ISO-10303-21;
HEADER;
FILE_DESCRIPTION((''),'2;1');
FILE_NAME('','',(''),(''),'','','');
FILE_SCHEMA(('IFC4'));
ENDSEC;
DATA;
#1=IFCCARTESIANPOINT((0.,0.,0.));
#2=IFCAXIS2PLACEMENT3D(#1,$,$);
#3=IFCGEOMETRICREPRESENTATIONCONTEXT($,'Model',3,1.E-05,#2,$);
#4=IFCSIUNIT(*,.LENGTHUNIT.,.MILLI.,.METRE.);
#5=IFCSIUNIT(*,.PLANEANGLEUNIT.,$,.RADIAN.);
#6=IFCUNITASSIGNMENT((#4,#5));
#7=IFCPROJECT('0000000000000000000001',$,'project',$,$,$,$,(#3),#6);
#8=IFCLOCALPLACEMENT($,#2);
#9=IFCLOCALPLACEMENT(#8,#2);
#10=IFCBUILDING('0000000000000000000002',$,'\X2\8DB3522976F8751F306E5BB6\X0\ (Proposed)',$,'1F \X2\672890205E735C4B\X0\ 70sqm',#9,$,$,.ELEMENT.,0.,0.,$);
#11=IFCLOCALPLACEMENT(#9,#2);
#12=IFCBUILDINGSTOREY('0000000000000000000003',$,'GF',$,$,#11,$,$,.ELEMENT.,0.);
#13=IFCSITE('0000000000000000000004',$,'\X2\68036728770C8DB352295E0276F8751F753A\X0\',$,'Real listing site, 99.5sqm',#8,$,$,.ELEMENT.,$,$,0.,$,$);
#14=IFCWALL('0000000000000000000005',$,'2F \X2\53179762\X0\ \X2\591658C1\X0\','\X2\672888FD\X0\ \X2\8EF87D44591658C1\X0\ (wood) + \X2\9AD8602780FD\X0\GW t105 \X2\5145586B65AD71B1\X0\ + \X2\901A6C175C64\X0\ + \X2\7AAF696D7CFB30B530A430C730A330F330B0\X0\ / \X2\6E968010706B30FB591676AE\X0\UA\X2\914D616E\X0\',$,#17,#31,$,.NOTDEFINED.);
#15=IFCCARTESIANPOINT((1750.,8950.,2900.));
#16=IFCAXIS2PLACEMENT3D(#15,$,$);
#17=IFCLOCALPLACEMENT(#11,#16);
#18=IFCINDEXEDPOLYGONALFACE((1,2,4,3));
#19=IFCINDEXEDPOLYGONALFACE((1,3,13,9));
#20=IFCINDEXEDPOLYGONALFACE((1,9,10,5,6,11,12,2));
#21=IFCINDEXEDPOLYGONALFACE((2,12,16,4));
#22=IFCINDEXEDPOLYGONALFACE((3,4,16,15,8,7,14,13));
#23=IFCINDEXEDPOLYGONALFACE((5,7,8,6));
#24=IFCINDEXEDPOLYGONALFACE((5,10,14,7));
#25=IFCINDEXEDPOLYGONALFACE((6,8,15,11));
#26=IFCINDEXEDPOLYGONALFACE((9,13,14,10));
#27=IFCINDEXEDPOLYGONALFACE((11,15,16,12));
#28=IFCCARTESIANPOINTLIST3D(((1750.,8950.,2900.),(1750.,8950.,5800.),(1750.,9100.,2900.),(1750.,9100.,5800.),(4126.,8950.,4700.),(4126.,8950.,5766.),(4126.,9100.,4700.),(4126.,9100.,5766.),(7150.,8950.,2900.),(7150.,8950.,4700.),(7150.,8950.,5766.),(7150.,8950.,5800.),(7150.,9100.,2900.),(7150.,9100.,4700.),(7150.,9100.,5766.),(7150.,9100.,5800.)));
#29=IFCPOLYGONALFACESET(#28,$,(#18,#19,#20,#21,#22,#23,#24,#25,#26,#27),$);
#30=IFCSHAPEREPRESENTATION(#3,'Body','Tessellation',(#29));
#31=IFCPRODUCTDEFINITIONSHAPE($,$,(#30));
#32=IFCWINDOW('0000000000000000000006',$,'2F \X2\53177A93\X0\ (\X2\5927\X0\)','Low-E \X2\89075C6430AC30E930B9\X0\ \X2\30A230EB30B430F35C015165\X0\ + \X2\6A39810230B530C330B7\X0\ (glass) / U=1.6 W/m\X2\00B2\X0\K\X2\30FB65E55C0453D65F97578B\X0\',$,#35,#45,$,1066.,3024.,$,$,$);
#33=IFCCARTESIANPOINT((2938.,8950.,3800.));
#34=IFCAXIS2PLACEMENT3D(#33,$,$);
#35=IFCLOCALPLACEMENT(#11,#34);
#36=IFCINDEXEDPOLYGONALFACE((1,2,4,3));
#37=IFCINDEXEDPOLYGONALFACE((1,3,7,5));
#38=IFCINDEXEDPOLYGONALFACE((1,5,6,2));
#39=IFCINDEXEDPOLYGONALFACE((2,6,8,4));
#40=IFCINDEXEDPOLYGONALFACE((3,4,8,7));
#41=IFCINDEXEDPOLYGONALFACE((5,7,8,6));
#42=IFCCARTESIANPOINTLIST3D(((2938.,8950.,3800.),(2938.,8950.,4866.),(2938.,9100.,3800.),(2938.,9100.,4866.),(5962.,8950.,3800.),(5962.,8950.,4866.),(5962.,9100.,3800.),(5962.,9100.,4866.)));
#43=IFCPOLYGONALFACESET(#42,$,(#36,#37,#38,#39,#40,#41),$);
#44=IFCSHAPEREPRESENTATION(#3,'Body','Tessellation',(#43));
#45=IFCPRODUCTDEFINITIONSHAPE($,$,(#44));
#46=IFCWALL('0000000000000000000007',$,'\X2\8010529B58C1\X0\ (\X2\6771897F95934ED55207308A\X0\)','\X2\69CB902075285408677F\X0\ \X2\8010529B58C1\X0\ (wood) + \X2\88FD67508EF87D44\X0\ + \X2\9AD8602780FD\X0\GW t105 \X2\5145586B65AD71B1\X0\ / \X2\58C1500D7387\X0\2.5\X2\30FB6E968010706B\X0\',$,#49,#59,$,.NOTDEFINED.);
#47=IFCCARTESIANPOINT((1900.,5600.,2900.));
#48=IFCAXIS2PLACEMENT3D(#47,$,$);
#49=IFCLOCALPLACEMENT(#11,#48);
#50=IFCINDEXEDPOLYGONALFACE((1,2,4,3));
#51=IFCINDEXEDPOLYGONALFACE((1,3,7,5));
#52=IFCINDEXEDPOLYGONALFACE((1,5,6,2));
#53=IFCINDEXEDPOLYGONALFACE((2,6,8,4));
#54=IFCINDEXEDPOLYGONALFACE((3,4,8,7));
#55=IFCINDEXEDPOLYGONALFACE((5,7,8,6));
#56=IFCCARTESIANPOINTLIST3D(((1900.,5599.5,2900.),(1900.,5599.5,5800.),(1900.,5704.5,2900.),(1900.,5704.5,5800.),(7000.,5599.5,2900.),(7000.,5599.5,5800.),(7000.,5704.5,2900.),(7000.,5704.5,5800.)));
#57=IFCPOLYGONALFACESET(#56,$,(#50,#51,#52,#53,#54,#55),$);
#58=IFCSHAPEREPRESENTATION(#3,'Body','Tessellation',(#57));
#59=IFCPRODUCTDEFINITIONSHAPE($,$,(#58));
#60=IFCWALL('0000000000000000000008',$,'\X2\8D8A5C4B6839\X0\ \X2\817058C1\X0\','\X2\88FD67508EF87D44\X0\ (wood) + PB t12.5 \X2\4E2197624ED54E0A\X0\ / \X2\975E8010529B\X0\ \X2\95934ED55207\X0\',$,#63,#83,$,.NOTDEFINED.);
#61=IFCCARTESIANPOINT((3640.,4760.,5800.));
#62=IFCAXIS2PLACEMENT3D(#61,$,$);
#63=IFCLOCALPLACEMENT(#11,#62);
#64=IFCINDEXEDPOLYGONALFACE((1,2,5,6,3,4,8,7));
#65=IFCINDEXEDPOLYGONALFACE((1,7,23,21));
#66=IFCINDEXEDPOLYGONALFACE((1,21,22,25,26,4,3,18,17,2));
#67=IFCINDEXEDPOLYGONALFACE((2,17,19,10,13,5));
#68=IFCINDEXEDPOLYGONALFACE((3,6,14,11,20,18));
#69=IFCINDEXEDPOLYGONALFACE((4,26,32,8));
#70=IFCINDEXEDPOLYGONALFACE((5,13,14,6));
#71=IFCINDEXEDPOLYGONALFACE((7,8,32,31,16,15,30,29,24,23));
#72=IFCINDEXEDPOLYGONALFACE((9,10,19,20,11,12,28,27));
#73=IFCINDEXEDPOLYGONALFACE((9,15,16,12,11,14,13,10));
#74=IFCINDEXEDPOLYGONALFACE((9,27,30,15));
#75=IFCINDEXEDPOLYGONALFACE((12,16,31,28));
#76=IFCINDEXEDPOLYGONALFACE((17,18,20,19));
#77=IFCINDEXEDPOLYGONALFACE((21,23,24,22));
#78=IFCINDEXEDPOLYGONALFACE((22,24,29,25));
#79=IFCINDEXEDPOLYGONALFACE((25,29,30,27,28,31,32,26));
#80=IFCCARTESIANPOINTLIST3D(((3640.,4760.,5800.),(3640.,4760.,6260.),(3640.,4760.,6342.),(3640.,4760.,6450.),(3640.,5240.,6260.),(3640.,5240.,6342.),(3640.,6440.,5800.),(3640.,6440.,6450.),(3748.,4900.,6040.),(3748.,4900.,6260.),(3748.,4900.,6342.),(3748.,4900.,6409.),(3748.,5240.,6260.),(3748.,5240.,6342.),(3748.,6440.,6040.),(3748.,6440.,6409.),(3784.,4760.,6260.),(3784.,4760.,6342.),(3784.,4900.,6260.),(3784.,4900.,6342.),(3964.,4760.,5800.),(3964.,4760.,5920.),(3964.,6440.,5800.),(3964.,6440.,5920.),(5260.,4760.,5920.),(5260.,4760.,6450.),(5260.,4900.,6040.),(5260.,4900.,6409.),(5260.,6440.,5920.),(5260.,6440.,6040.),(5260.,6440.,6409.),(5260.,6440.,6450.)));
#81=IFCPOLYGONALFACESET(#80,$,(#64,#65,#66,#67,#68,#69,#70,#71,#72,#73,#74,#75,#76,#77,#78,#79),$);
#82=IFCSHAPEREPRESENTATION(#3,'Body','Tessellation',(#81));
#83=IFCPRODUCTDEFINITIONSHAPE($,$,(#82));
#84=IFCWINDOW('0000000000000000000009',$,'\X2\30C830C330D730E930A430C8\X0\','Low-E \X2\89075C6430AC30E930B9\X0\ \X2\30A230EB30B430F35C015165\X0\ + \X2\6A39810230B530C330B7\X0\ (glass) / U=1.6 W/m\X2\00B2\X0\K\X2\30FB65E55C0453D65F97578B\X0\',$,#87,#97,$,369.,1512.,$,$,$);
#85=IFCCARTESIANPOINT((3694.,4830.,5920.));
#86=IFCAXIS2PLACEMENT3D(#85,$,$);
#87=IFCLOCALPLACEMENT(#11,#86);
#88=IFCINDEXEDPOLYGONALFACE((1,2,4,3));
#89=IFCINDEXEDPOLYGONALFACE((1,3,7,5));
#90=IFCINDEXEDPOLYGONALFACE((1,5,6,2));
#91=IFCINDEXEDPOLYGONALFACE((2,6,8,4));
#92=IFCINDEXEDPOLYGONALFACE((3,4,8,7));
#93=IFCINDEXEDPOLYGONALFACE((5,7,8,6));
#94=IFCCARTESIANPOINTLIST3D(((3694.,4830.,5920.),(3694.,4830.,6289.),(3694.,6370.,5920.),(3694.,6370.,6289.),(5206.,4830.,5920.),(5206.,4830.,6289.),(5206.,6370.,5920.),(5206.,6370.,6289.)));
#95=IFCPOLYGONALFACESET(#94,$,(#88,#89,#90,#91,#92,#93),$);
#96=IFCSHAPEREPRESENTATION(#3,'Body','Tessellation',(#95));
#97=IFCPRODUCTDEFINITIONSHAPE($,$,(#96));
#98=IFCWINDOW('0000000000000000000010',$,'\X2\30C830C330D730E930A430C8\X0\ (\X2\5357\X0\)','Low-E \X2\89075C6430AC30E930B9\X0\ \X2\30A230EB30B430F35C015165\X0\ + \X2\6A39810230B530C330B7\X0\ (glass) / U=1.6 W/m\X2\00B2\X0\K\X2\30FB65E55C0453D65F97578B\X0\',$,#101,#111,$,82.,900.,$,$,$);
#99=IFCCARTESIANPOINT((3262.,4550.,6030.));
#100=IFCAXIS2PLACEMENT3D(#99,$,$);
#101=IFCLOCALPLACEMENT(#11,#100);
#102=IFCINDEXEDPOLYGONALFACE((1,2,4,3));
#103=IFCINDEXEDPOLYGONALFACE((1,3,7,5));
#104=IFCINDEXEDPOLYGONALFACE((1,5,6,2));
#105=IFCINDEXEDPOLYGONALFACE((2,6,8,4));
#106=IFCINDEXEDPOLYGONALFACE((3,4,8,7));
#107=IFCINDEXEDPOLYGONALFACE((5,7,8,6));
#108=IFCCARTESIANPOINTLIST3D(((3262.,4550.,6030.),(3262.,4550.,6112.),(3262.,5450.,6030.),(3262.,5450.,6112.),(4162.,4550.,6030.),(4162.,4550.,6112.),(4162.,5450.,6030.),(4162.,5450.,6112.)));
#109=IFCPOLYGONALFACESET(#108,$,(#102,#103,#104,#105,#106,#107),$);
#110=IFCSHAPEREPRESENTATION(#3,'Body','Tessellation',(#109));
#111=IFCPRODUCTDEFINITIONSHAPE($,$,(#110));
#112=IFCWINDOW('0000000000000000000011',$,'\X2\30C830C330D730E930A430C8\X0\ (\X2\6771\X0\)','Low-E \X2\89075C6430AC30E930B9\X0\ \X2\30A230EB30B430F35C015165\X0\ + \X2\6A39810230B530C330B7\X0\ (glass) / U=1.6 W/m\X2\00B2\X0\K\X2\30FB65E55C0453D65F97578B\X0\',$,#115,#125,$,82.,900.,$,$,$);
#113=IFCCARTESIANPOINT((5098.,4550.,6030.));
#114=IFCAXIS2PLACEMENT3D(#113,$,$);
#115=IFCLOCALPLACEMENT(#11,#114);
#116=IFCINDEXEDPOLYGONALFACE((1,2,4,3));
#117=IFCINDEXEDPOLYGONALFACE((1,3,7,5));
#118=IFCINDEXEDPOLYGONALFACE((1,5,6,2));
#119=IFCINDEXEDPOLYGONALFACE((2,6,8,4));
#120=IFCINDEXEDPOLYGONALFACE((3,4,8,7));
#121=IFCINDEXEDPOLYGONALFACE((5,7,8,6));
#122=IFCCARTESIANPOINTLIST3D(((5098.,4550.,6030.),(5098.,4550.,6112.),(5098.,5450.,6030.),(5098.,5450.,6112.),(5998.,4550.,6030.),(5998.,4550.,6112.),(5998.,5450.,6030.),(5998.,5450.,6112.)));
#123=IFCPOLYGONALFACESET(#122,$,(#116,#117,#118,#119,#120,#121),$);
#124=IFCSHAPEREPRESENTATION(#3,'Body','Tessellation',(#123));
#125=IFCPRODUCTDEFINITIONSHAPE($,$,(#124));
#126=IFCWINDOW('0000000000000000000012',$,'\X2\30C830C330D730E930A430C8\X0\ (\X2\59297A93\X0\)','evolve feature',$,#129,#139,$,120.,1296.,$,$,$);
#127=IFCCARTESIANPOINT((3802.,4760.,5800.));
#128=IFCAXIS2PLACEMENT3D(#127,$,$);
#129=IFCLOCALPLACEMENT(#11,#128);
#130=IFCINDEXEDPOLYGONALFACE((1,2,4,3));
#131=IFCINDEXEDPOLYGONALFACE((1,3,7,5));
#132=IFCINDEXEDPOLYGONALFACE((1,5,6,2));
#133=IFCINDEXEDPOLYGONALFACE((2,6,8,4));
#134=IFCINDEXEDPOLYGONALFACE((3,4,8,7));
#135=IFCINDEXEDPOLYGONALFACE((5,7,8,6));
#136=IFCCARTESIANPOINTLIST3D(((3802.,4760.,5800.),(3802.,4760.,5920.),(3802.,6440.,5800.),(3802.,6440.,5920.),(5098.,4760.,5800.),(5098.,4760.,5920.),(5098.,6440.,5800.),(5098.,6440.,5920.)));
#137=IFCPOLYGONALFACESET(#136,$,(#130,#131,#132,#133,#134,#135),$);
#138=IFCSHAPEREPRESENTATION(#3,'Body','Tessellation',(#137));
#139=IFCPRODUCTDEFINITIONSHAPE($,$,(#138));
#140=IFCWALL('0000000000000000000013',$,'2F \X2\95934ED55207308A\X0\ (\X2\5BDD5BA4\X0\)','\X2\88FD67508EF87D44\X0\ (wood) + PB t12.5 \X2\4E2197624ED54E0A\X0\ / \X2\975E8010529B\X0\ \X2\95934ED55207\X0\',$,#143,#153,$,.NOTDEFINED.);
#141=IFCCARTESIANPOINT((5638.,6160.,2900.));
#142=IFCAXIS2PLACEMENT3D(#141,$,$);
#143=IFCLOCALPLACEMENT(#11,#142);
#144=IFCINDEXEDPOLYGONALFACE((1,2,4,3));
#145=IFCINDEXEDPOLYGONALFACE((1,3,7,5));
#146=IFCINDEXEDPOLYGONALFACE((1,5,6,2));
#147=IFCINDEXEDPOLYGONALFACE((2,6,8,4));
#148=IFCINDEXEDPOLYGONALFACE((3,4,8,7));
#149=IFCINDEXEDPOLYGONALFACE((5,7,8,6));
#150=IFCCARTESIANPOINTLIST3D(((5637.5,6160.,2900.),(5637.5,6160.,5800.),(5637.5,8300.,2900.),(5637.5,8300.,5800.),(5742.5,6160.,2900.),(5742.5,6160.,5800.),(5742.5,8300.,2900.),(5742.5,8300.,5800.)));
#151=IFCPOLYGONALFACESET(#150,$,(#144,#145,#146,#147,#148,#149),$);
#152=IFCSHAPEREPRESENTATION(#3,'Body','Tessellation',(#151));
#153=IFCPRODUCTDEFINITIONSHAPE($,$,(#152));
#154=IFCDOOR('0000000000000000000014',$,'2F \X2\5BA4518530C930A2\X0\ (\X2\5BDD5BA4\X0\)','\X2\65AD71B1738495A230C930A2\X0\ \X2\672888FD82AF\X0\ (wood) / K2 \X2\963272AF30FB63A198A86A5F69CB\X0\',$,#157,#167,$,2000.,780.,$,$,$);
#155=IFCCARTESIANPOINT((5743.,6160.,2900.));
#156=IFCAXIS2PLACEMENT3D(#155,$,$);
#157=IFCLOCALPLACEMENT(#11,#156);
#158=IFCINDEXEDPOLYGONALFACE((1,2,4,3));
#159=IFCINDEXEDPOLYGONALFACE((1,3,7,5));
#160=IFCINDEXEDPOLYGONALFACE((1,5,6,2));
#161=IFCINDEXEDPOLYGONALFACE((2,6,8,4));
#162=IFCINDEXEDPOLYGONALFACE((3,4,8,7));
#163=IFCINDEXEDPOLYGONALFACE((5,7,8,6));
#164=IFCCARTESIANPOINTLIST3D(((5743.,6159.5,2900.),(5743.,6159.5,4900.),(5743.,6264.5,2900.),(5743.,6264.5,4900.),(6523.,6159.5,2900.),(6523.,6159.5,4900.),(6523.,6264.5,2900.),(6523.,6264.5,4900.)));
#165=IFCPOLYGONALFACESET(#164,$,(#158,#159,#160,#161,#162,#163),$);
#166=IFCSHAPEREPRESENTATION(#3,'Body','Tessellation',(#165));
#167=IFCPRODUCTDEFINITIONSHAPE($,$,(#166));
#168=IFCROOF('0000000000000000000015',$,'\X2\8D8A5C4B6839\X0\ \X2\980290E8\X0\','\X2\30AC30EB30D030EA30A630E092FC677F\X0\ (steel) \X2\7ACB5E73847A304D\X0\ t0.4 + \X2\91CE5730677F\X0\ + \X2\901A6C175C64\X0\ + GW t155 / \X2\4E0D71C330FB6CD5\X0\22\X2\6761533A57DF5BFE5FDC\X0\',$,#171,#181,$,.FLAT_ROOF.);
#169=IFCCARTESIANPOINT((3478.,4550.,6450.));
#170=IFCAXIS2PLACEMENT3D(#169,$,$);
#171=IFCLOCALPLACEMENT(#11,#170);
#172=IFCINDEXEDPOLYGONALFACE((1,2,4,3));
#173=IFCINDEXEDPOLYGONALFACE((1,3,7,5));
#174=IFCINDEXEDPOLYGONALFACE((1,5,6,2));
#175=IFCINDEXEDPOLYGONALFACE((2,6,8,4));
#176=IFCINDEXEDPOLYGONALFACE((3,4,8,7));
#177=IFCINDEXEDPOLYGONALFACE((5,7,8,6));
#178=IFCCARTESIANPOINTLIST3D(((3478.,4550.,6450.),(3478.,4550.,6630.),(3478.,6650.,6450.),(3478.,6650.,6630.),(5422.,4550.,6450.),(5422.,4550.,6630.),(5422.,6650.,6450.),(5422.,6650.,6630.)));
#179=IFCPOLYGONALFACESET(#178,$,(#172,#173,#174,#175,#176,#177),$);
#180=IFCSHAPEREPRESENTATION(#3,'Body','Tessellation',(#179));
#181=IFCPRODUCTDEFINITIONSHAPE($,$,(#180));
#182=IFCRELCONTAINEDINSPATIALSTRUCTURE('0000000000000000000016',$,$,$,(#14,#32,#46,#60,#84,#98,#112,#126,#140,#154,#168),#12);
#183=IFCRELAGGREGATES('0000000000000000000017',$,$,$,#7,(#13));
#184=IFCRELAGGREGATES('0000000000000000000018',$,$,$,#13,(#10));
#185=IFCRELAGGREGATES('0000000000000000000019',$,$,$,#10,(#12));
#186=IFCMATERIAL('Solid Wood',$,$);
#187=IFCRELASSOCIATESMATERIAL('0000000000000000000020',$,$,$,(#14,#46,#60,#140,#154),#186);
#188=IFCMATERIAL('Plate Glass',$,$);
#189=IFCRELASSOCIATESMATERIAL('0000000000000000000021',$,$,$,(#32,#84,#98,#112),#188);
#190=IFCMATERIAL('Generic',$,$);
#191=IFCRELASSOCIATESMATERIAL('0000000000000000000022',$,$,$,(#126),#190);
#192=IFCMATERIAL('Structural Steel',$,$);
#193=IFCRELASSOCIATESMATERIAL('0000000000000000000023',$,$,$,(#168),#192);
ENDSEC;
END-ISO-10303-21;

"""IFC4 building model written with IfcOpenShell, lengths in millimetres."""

from ifc_helpers import new_model, si_unit, frame, frame_2d, origin, place, context, project, spatial, rectangle, extrude, material, element, fill, save


model = new_model("IFC4")

# Units and contexts
model_context = context("Model", 3, precision=1e-05, world=origin())
ifc_project = project(units=[si_unit("LENGTHUNIT", "METRE", prefix="MILLI"), si_unit("PLANEANGLEUNIT", "RADIAN")], contexts=[model_context])

# Site, building, storey
site_placement = place(None, origin())
site = spatial("IfcSite", under=ifc_project, at=site_placement, Name="栃木県足利市相生町", ObjectType="Real listing site, 99.5sqm", CompositionType="ELEMENT", RefElevation=0.0)
building_placement = place(site_placement, origin())
building = spatial("IfcBuilding", under=site, at=building_placement, Name="足利相生の家 (Proposed)", ObjectType="1F 木造平屋 70sqm", CompositionType="ELEMENT", ElevationOfRefHeight=0.0, ElevationOfTerrain=0.0)
storey_placement = place(building_placement, origin())
storey = spatial("IfcBuildingStorey", under=building, at=storey_placement, Name="GF", CompositionType="ELEMENT", Elevation=0.0)

# Wall, opening, window
ifc_material_1 = material(Name="Solid Wood")
wall_1_placement = place(storey_placement, frame((1750.0, 8950.0, 2900.0)))
wall_1 = element("IfcWall", 1, at=wall_1_placement, inside=storey, material=ifc_material_1, Name="2F 北面 外壁", Description="木製 軸組外壁 (wood) + 高性能GW t105 充填断熱 + 通気層 + 窯業系サイディング / 準耐火・外皮UA配慮", PredefinedType="NOTDEFINED", context=model_context, shape_type="SweptSolid", body=[
    extrude(rectangle(XDim=5400.0, YDim=150.0, at=frame_2d((2700.0, 75.0))), frame((1750.0, 8950.0, 2900.0)), (0.0, 0.0, 1.0), 2900.0),
])
opening_1_placement = place(storey_placement, frame((2938.0, 8950.0, 3800.0)))
opening_1 = element("IfcOpeningElement", 2, at=opening_1_placement, cuts=wall_1, PredefinedType="NOTDEFINED", context=model_context, shape_type="SweptSolid", body=[
    extrude(rectangle(XDim=3024.0, YDim=150.0, at=frame_2d((1512.0, 75.0))), frame((2938.0, 8950.0, 3800.0)), (0.0, 0.0, 1.0), 1066.0),
])
ifc_material_2 = material(Name="Plate Glass")
window_1_placement = place(storey_placement, frame((2938.0, 8950.0, 3800.0)))
window_1 = element("IfcWindow", 3, at=window_1_placement, inside=storey, material=ifc_material_2, Name="2F 北窓 (大)", Description="Low-E 複層ガラス アルゴン封入 + 樹脂サッシ (glass) / U=1.6 W/m²K・日射取得型", OverallHeight=1066.0, OverallWidth=3024.0, context=model_context, shape_type="SweptSolid", body=[
    extrude(rectangle(XDim=3024.0, YDim=150.0, at=frame_2d((1512.0, 75.0))), frame((2938.0, 8950.0, 3800.0)), (0.0, 0.0, 1.0), 1066.0),
])
fill(opening_1, window_1)

# Wall
wall_2_placement = place(storey_placement, frame((1900.0, 5600.0, 2900.0)))
element("IfcWall", 4, at=wall_2_placement, inside=storey, material=ifc_material_1, Name="耐力壁 (東西間仕切り)", Description="構造用合板 耐力壁 (wood) + 製材軸組 + 高性能GW t105 充填断熱 / 壁倍率2.5・準耐火", PredefinedType="NOTDEFINED", context=model_context, shape_type="SweptSolid", body=[
    extrude(rectangle(XDim=5100.0, YDim=105.0, at=frame_2d((2550.0, 52.0))), frame((1900.0, 5600.0, 2900.0)), (0.0, 0.0, 1.0), 2900.0),
])

# Wall, openings, windows
wall_3_placement = place(storey_placement, frame((3640.0, 4760.0, 5800.0)))
wall_3 = element("IfcWall", 5, at=wall_3_placement, inside=storey, material=ifc_material_1, Name="越屋根 腰壁", Description="製材軸組 (wood) + PB t12.5 両面仕上 / 非耐力 間仕切", PredefinedType="NOTDEFINED", context=model_context, shape_type="SweptSolid", body=[
    extrude(rectangle(XDim=1620.0, YDim=1680.0, at=frame_2d((810.0, 840.0))), frame((3640.0, 4760.0, 5800.0)), (0.0, 0.0, 1.0), 650.0),
])
opening_2_placement = place(storey_placement, frame((3694.0, 4830.0, 5920.0)))
opening_2 = element("IfcOpeningElement", 6, at=opening_2_placement, cuts=wall_3, PredefinedType="NOTDEFINED", context=model_context, shape_type="SweptSolid", body=[
    extrude(rectangle(XDim=1512.0, YDim=1540.0, at=frame_2d((756.0, 770.0))), frame((3694.0, 4830.0, 5920.0)), (0.0, 0.0, 1.0), 369.0),
])
opening_3_placement = place(storey_placement, frame((3262.0, 4550.0, 6030.0)))
opening_3 = element("IfcOpeningElement", 7, at=opening_3_placement, cuts=wall_3, PredefinedType="NOTDEFINED", context=model_context, shape_type="SweptSolid", body=[
    extrude(rectangle(XDim=900.0, YDim=900.0, at=frame_2d((450.0, 450.0))), frame((3262.0, 4550.0, 6030.0)), (0.0, 0.0, 1.0), 82.0),
])
opening_4_placement = place(storey_placement, frame((5098.0, 4550.0, 6030.0)))
opening_4 = element("IfcOpeningElement", 8, at=opening_4_placement, cuts=wall_3, PredefinedType="NOTDEFINED", context=model_context, shape_type="SweptSolid", body=[
    extrude(rectangle(XDim=900.0, YDim=900.0, at=frame_2d((450.0, 450.0))), frame((5098.0, 4550.0, 6030.0)), (0.0, 0.0, 1.0), 82.0),
])
opening_5_placement = place(storey_placement, frame((3802.0, 4760.0, 5800.0)))
opening_5 = element("IfcOpeningElement", 9, at=opening_5_placement, cuts=wall_3, PredefinedType="NOTDEFINED", context=model_context, shape_type="SweptSolid", body=[
    extrude(rectangle(XDim=1296.0, YDim=1680.0, at=frame_2d((648.0, 840.0))), frame((3802.0, 4760.0, 5800.0)), (0.0, 0.0, 1.0), 120.0),
])
window_2_placement = place(storey_placement, frame((3694.0, 4830.0, 5920.0)))
window_2 = element("IfcWindow", 10, at=window_2_placement, inside=storey, material=ifc_material_2, Name="トップライト", Description="Low-E 複層ガラス アルゴン封入 + 樹脂サッシ (glass) / U=1.6 W/m²K・日射取得型", OverallHeight=369.0, OverallWidth=1512.0, context=model_context, shape_type="SweptSolid", body=[
    extrude(rectangle(XDim=1512.0, YDim=1540.0, at=frame_2d((756.0, 770.0))), frame((3694.0, 4830.0, 5920.0)), (0.0, 0.0, 1.0), 369.0),
])
fill(opening_2, window_2)
window_3_placement = place(storey_placement, frame((3262.0, 4550.0, 6030.0)))
window_3 = element("IfcWindow", 11, at=window_3_placement, inside=storey, material=ifc_material_2, Name="トップライト (南)", Description="Low-E 複層ガラス アルゴン封入 + 樹脂サッシ (glass) / U=1.6 W/m²K・日射取得型", OverallHeight=82.0, OverallWidth=900.0, context=model_context, shape_type="SweptSolid", body=[
    extrude(rectangle(XDim=900.0, YDim=900.0, at=frame_2d((450.0, 450.0))), frame((3262.0, 4550.0, 6030.0)), (0.0, 0.0, 1.0), 82.0),
])
fill(opening_3, window_3)
window_4_placement = place(storey_placement, frame((5098.0, 4550.0, 6030.0)))
window_4 = element("IfcWindow", 12, at=window_4_placement, inside=storey, material=ifc_material_2, Name="トップライト (東)", Description="Low-E 複層ガラス アルゴン封入 + 樹脂サッシ (glass) / U=1.6 W/m²K・日射取得型", OverallHeight=82.0, OverallWidth=900.0, context=model_context, shape_type="SweptSolid", body=[
    extrude(rectangle(XDim=900.0, YDim=900.0, at=frame_2d((450.0, 450.0))), frame((5098.0, 4550.0, 6030.0)), (0.0, 0.0, 1.0), 82.0),
])
fill(opening_4, window_4)
ifc_material_3 = material(Name="Generic")
window_5_placement = place(storey_placement, frame((3802.0, 4760.0, 5800.0)))
window_5 = element("IfcWindow", 13, at=window_5_placement, inside=storey, material=ifc_material_3, Name="トップライト (天窓)", Description="evolve feature", OverallHeight=120.0, OverallWidth=1296.0, context=model_context, shape_type="SweptSolid", body=[
    extrude(rectangle(XDim=1296.0, YDim=1680.0, at=frame_2d((648.0, 840.0))), frame((3802.0, 4760.0, 5800.0)), (0.0, 0.0, 1.0), 120.0),
])
fill(opening_5, window_5)

# Wall
wall_4_placement = place(storey_placement, frame((5638.0, 6160.0, 2900.0)))
element("IfcWall", 14, at=wall_4_placement, inside=storey, material=ifc_material_1, Name="2F 間仕切り (寝室)", Description="製材軸組 (wood) + PB t12.5 両面仕上 / 非耐力 間仕切", PredefinedType="NOTDEFINED", context=model_context, shape_type="SweptSolid", body=[
    extrude(rectangle(XDim=105.0, YDim=2140.0, at=frame_2d((52.0, 1070.0))), frame((5638.0, 6160.0, 2900.0)), (0.0, 0.0, 1.0), 2900.0),
])

# Door
door_placement = place(storey_placement, frame((5743.0, 6160.0, 2900.0)))
element("IfcDoor", 15, at=door_placement, inside=storey, material=ifc_material_1, Name="2F 室内ドア (寝室)", Description="断熱玄関ドア 木製芯 (wood) / K2 防犯・採風機構", OverallHeight=2000.0, OverallWidth=780.0, context=model_context, shape_type="SweptSolid", body=[
    extrude(rectangle(XDim=780.0, YDim=105.0, at=frame_2d((390.0, 52.0))), frame((5743.0, 6160.0, 2900.0)), (0.0, 0.0, 1.0), 2000.0),
])

# Roof
ifc_material_4 = material(Name="Structural Steel")
roof_placement = place(storey_placement, frame((3478.0, 4550.0, 6450.0)))
element("IfcRoof", 16, at=roof_placement, inside=storey, material=ifc_material_4, Name="越屋根 頂部", Description="ガルバリウム鋼板 (steel) 立平葺き t0.4 + 野地板 + 通気層 + GW t155 / 不燃・法22条区域対応", PredefinedType="FLAT_ROOF", context=model_context, shape_type="SweptSolid", body=[
    extrude(rectangle(XDim=1944.0, YDim=2100.0, at=frame_2d((972.0, 1050.0))), frame((3478.0, 4550.0, 6450.0)), (0.0, 0.0, 1.0), 180.0),
])

save(model, "model.ifc")
